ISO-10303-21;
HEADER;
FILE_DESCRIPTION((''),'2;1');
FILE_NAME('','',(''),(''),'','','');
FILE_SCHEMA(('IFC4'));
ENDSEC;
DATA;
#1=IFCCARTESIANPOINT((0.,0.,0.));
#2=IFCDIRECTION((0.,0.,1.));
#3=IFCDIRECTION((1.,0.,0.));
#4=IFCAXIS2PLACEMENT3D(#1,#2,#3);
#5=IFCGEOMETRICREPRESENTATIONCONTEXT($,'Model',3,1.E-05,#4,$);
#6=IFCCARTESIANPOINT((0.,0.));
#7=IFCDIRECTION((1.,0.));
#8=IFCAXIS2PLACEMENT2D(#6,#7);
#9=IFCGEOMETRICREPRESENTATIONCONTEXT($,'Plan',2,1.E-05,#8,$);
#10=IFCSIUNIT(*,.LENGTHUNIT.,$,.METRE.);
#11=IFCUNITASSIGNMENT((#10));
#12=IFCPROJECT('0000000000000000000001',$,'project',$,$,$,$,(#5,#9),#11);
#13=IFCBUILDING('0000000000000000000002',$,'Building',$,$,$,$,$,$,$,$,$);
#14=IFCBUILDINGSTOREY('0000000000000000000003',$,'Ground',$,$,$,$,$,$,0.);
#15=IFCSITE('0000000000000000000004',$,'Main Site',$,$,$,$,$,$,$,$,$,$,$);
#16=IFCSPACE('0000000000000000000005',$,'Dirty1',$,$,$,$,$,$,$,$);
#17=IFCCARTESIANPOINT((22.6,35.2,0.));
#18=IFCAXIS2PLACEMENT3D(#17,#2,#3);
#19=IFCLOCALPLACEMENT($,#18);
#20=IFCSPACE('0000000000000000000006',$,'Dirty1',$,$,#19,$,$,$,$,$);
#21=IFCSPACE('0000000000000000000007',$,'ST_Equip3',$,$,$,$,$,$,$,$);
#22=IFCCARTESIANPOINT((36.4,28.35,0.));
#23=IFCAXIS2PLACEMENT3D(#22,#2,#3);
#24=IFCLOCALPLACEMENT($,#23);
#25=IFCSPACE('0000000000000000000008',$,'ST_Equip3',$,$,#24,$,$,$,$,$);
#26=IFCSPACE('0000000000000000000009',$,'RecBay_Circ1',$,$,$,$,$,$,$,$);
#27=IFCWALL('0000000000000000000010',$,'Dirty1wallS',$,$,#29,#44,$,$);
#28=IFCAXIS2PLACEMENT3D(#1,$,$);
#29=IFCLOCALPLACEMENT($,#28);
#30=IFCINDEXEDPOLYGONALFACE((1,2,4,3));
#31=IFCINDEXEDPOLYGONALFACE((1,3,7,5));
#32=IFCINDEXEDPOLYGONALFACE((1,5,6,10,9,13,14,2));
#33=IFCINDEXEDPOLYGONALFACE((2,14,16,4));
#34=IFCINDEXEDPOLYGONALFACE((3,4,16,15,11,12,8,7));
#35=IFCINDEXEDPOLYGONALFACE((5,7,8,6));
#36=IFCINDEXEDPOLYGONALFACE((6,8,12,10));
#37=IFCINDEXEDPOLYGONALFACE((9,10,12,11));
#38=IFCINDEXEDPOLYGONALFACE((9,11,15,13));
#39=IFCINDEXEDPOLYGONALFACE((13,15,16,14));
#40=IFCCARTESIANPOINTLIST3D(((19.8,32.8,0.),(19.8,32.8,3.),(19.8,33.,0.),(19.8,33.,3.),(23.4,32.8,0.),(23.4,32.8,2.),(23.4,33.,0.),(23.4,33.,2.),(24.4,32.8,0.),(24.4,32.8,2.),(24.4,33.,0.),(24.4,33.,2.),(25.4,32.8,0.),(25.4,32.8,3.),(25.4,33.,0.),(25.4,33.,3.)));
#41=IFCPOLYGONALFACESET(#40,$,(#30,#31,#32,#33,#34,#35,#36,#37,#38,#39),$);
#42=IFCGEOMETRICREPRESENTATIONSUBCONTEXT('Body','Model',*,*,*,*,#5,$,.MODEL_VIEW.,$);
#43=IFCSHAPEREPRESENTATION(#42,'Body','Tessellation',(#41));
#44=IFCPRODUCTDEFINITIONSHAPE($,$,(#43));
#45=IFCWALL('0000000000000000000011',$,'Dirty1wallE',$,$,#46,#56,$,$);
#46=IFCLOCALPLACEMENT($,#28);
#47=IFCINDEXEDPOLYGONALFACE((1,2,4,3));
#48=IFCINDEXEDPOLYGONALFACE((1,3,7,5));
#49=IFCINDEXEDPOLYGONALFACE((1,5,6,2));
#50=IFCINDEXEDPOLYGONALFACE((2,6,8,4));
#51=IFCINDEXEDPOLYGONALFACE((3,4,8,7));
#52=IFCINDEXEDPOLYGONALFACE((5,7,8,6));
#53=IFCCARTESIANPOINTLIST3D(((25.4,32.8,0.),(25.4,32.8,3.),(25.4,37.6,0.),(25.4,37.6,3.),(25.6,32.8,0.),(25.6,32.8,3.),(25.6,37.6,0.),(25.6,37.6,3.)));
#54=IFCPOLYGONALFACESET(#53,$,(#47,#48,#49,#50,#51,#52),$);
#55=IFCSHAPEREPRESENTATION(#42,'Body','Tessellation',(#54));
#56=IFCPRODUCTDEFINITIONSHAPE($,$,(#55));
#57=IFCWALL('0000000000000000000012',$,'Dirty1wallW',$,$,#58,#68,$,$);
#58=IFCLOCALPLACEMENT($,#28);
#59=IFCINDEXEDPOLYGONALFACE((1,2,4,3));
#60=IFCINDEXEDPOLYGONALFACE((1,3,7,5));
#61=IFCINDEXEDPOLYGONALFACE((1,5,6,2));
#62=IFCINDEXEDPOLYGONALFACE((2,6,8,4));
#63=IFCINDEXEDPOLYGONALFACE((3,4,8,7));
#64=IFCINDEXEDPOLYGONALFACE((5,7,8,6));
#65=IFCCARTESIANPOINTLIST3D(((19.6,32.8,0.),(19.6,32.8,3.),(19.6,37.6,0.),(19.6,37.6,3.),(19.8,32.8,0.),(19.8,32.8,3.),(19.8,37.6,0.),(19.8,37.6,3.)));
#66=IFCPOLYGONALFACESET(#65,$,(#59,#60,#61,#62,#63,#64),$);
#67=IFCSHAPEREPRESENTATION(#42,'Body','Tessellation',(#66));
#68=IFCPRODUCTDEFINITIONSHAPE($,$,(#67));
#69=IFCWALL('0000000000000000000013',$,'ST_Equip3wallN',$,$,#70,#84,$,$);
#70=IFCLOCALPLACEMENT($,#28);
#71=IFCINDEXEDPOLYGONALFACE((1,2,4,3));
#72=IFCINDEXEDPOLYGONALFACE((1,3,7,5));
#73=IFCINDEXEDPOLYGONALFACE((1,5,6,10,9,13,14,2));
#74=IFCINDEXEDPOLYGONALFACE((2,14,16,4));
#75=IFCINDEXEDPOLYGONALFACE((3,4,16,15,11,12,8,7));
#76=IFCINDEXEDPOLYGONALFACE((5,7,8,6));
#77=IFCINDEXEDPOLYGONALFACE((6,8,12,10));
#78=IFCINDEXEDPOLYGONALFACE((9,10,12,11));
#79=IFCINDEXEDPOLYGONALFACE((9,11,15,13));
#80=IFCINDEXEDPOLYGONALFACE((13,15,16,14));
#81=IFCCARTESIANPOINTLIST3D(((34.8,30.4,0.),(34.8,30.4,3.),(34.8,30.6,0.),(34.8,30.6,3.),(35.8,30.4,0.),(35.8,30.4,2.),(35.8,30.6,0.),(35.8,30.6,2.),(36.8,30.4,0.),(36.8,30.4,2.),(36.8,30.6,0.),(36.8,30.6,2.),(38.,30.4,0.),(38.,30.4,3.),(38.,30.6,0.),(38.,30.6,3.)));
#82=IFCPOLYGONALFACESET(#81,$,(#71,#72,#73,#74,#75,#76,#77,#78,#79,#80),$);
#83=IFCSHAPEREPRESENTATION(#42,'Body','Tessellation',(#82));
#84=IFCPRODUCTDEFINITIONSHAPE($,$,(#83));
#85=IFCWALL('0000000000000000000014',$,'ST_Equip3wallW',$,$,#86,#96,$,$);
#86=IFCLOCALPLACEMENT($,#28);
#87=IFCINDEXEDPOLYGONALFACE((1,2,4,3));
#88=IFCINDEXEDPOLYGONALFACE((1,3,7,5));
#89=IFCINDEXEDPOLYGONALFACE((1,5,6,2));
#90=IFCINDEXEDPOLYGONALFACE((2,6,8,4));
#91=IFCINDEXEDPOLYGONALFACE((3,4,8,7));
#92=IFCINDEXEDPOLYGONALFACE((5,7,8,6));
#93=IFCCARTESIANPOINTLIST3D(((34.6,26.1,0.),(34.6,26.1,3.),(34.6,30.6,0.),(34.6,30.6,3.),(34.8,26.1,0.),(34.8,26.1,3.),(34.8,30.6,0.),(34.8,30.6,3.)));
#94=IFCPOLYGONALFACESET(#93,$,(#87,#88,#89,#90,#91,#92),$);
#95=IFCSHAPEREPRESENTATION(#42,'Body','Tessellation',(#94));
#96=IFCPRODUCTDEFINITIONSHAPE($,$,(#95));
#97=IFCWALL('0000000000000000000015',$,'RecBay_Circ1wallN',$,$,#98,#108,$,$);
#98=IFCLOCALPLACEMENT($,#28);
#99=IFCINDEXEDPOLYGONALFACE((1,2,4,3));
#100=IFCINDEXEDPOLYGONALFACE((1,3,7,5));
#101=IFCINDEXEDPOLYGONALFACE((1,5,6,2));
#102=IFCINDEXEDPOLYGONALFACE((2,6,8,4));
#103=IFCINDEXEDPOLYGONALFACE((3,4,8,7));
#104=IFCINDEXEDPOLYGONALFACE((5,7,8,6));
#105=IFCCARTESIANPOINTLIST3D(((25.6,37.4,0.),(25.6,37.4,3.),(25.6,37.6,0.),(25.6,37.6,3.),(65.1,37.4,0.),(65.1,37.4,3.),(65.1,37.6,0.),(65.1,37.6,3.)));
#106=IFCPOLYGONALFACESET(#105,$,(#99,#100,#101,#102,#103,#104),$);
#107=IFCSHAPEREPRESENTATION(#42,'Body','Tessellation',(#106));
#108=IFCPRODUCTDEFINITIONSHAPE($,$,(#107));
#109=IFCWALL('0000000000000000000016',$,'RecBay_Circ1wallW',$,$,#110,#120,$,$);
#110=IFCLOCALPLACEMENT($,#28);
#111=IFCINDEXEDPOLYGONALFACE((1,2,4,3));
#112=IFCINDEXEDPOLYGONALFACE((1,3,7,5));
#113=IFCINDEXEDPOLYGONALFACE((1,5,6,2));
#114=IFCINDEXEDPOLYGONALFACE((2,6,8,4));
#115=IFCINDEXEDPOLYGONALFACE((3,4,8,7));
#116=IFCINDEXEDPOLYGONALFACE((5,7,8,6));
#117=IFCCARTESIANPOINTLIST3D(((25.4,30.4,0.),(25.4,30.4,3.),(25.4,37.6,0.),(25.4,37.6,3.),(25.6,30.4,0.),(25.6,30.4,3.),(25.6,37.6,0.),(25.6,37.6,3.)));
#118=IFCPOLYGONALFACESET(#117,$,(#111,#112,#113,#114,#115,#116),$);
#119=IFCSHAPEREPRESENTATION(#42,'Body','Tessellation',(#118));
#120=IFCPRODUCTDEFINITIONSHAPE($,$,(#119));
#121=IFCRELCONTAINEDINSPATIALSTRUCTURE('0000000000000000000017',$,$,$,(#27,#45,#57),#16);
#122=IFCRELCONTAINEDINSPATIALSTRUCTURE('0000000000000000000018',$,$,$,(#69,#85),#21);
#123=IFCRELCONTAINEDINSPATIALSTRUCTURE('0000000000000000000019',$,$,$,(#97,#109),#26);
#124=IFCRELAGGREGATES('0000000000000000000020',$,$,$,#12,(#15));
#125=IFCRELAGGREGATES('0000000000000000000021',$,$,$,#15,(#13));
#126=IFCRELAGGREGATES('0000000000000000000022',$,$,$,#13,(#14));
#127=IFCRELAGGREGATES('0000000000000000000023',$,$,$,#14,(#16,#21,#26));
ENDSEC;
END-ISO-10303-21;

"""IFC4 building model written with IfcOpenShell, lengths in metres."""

from ifc_helpers import new_model, si_unit, frame, origin_with_axes, origin_2d_with_axis, place, context, subcontext, project, spatial, indexed_curve, outline, extrude, element, save


model = new_model("IFC4")

# Units and contexts
model_context = context("Model", 3, precision=1e-05, world=origin_with_axes())
plan_context = context("Plan", 2, precision=1e-05, world=origin_2d_with_axis())
body_context = subcontext(model_context, "Body", "Model", "MODEL_VIEW")
ifc_project = project(units=[si_unit("LENGTHUNIT", "METRE")], contexts=[model_context, plan_context])

# Site, building, storey
site = spatial("IfcSite", under=ifc_project, Name="Main Site")
building = spatial("IfcBuilding", under=site, Name="Building")
storey = spatial("IfcBuildingStorey", under=building, Name="Ground", Elevation=0.0)

# Shared definitions
space_1 = spatial("IfcSpace", under=storey, Name="Dirty1")

# Wall
wall_1_placement = place(None, frame((19.8, 32.8, 0.0), z_axis=(0.0, 0.0, 1.0), x_axis=(1.0, 0.0, 0.0)))
wall_1 = element("IfcWall", 1, at=wall_1_placement, inside=space_1, Name="Dirty1wallS", context=body_context, shape_type="SweptSolid", body=[
    extrude(outline(indexed_curve([(0.0, 0.0), (0.0, 0.2), (5.6, 0.2), (5.6, 0.0), (0.0, 0.0)], self_intersect=False)), origin_with_axes(), (0.0, 0.0, 1.0), 3.0),
])

# Shared definitions
space_2_placement = place(None, frame((22.6, 35.2, 0.0), z_axis=(0.0, 0.0, 1.0), x_axis=(1.0, 0.0, 0.0)))
space_2 = spatial("IfcSpace", at=space_2_placement, Name="Dirty1")

# Opening
opening_1_placement = place(wall_1_placement, frame((3.6, 0.0, 0.0), z_axis=(0.0, 0.0, 1.0), x_axis=(1.0, 0.0, 0.0)))
element("IfcOpeningElement", 2, at=opening_1_placement, inside=space_2, cuts=wall_1, context=body_context, shape_type="SweptSolid", body=[
    extrude(outline(indexed_curve([(0.0, 0.0), (0.0, 0.4), (1.0, 0.4), (1.0, 0.0), (0.0, 0.0)], self_intersect=False)), origin_with_axes(), (0.0, 0.0, 1.0), 2.0),
])

# Walls
for number, where, z_axis, x_axis, name in (
    (3, (25.6, 32.8, 0.0), (0.0, 0.0, 1.0), (0.0, 1.0, 0.0), "Dirty1wallE"),
    (4, (19.8, 32.8, 0.0), (0.0, 0.0, 1.0), (0.0, 1.0, 0.0), "Dirty1wallW"),
):
    element("IfcWall", number, at=place(None, frame(where, z_axis=z_axis, x_axis=x_axis)), inside=space_1, Name=name, context=body_context, shape_type="SweptSolid", body=[
        extrude(outline(indexed_curve([(0.0, 0.0), (0.0, 0.2), (4.8, 0.2), (4.8, 0.0), (0.0, 0.0)], self_intersect=False)), origin_with_axes(), (0.0, 0.0, 1.0), 3.0),
    ])

# Shared definitions
space_3 = spatial("IfcSpace", under=storey, Name="ST_Equip3")

# Wall
wall_2_placement = place(None, frame((34.8, 30.4, 0.0), z_axis=(0.0, 0.0, 1.0), x_axis=(1.0, 0.0, 0.0)))
wall_2 = element("IfcWall", 5, at=wall_2_placement, inside=space_3, Name="ST_Equip3wallN", context=body_context, shape_type="SweptSolid", body=[
    extrude(outline(indexed_curve([(0.0, 0.0), (0.0, 0.2), (3.2, 0.2), (3.2, 0.0), (0.0, 0.0)], self_intersect=False)), origin_with_axes(), (0.0, 0.0, 1.0), 3.0),
])

# Shared definitions
space_4_placement = place(None, frame((36.4, 28.35, 0.0), z_axis=(0.0, 0.0, 1.0), x_axis=(1.0, 0.0, 0.0)))
space_4 = spatial("IfcSpace", at=space_4_placement, Name="ST_Equip3")

# Opening
opening_2_placement = place(wall_2_placement, frame((1.0, 0.0, 0.0), z_axis=(0.0, 0.0, 1.0), x_axis=(1.0, 0.0, 0.0)))
element("IfcOpeningElement", 6, at=opening_2_placement, inside=space_4, cuts=wall_2, context=body_context, shape_type="SweptSolid", body=[
    extrude(outline(indexed_curve([(0.0, 0.0), (0.0, 0.4), (1.0, 0.4), (1.0, 0.0), (0.0, 0.0)], self_intersect=False)), origin_with_axes(), (0.0, 0.0, 1.0), 2.0),
])

# Wall
wall_3_placement = place(None, frame((34.8, 26.1, 0.0), z_axis=(0.0, 0.0, 1.0), x_axis=(0.0, 1.0, 0.0)))
element("IfcWall", 7, at=wall_3_placement, inside=space_3, Name="ST_Equip3wallW", context=body_context, shape_type="SweptSolid", body=[
    extrude(outline(indexed_curve([(0.0, 0.0), (0.0, 0.2), (4.5, 0.2), (4.5, 0.0), (0.0, 0.0)], self_intersect=False)), origin_with_axes(), (0.0, 0.0, 1.0), 3.0),
])

# Shared definitions
space_5 = spatial("IfcSpace", under=storey, Name="RecBay_Circ1")

# Wall
wall_4_placement = place(None, frame((25.6, 37.4, 0.0), z_axis=(0.0, 0.0, 1.0), x_axis=(1.0, 0.0, 0.0)))
element("IfcWall", 8, at=wall_4_placement, inside=space_5, Name="RecBay_Circ1wallN", context=body_context, shape_type="SweptSolid", body=[
    extrude(outline(indexed_curve([(0.0, 0.0), (0.0, 0.2), (39.5, 0.2), (39.5, 0.0), (0.0, 0.0)], self_intersect=False)), origin_with_axes(), (0.0, 0.0, 1.0), 3.0),
])

# Wall
wall_5_placement = place(None, frame((25.6, 30.4, 0.0), z_axis=(0.0, 0.0, 1.0), x_axis=(0.0, 1.0, 0.0)))
element("IfcWall", 9, at=wall_5_placement, inside=space_5, Name="RecBay_Circ1wallW", context=body_context, shape_type="SweptSolid", body=[
    extrude(outline(indexed_curve([(0.0, 0.0), (0.0, 0.2), (7.2, 0.2), (7.2, 0.0), (0.0, 0.0)], self_intersect=False)), origin_with_axes(), (0.0, 0.0, 1.0), 3.0),
])

save(model, "model.ifc")
